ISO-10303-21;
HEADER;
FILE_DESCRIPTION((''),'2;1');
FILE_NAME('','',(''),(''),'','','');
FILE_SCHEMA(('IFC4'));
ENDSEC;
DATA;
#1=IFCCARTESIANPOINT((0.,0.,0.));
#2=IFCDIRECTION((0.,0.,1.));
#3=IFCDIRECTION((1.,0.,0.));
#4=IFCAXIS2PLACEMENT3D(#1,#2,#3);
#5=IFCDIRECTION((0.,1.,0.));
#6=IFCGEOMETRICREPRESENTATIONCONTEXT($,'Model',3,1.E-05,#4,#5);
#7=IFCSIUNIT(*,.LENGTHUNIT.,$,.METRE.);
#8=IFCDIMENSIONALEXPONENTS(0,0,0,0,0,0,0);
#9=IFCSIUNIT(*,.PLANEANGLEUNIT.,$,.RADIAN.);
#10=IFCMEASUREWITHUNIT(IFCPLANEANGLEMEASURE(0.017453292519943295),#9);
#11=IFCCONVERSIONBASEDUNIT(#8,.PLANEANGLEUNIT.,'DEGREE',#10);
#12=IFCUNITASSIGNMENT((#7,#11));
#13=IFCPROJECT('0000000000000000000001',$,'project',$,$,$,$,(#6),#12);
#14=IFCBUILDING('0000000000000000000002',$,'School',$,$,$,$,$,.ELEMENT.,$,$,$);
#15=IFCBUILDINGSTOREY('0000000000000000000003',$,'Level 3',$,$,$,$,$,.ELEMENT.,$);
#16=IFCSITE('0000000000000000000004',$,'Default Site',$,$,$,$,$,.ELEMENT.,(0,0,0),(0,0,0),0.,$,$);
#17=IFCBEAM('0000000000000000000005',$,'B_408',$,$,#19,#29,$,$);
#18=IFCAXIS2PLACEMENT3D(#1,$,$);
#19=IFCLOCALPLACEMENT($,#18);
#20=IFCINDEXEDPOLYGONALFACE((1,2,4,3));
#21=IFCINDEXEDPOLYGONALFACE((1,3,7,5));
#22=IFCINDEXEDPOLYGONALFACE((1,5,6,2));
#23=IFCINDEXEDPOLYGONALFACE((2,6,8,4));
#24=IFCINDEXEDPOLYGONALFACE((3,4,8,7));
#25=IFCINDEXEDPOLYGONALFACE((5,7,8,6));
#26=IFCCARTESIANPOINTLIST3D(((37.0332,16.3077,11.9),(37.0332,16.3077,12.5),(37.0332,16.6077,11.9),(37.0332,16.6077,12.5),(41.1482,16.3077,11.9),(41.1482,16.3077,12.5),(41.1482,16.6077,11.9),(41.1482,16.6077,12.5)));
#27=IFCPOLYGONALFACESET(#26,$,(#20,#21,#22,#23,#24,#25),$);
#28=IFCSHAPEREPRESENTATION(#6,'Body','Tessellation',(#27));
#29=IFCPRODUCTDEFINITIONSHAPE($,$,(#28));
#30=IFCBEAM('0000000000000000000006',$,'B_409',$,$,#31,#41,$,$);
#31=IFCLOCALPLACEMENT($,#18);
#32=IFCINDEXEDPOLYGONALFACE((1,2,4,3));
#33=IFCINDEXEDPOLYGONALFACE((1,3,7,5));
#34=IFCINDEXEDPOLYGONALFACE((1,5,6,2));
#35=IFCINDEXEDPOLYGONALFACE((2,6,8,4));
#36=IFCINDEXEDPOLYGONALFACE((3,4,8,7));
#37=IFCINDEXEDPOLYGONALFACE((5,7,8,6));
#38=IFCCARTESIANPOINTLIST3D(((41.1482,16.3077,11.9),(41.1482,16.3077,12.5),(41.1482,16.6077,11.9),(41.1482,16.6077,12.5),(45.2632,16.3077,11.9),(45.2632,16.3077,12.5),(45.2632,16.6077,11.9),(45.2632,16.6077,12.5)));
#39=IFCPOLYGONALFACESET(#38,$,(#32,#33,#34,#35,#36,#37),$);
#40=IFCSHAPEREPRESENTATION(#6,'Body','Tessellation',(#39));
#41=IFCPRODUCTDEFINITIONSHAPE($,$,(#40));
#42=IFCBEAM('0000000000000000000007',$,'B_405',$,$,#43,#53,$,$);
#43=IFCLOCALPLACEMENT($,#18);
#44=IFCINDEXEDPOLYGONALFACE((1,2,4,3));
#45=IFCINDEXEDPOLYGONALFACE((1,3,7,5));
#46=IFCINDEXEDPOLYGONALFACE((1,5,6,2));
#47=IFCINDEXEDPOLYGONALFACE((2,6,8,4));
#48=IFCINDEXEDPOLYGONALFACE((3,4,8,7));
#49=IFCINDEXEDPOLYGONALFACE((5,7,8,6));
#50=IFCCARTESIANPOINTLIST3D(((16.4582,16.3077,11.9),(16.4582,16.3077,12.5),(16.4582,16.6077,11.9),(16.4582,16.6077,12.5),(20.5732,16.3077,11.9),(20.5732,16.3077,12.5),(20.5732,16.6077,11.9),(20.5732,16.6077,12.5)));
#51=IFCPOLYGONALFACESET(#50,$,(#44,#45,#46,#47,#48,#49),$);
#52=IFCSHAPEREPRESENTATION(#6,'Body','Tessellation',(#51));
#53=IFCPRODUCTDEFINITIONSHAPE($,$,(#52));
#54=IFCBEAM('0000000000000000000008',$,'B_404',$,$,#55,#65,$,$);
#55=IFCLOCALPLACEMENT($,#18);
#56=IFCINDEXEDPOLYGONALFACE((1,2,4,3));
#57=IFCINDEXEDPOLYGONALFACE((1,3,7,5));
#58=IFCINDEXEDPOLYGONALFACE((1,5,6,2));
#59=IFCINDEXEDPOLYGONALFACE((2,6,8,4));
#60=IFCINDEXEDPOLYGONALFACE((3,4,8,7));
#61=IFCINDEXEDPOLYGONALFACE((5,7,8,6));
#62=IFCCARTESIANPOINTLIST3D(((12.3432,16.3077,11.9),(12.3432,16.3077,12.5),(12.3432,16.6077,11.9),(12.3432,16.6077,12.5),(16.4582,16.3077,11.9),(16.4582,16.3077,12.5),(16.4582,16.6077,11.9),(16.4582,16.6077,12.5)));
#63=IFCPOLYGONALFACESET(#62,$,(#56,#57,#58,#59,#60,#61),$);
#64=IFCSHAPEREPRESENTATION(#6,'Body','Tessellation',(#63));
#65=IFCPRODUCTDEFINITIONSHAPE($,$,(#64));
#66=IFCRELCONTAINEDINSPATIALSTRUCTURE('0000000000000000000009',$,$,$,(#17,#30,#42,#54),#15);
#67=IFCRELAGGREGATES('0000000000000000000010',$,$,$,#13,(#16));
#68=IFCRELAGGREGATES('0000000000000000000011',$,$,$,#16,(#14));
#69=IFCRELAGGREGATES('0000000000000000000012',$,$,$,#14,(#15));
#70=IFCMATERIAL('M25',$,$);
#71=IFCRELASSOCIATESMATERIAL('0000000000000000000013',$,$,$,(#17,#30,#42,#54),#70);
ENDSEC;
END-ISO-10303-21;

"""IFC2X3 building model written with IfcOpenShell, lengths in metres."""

from ifc_helpers import new_model, entity, si_unit, converted_unit, direction, frame, frame_2d, origin_with_axes, place, context, project, spatial, rectangle, extrude, material, element, save


model = new_model("IFC2X3")

# Units and contexts
model_context = context("Model", 3, precision=1e-05, world=origin_with_axes(), true_north=direction((0.0, 1.0, 0.0)))
ifc_project = project(units=[si_unit("LENGTHUNIT", "METRE"), converted_unit("PLANEANGLEUNIT", "DEGREE", entity("IfcPlaneAngleMeasure", 0.017453292519943295), si_unit("PLANEANGLEUNIT", "RADIAN"), dimensions=[0, 0, 0, 0, 0, 0, 0])], contexts=[model_context])

# Site, building, storey
site = spatial("IfcSite", under=ifc_project, Name="Default Site", CompositionType="ELEMENT", RefLatitude=(0, 0, 0), RefLongitude=(0, 0, 0), RefElevation=0.0)
building = spatial("IfcBuilding", under=site, Name="School", CompositionType="ELEMENT")
storey = spatial("IfcBuildingStorey", under=building, Name="Level 3", CompositionType="ELEMENT")

# Beams
ifc_material = material(Name="M25")
placement = place(None, origin_with_axes())
element("IfcBeam", 1, at=placement, inside=storey, material=ifc_material, Name="B_408", context=model_context, shape_type="SweptSolid", body=[
    extrude(rectangle(XDim=0.3, YDim=0.6, at=frame_2d((0.0, 0.0), x_axis=(0.0, 1.0, 0.0))), frame((37.0332, 16.4577, 12.2), z_axis=(1.0, 0.0, 0.0), x_axis=(0.0, 0.0, -1.0)), (0.0, 0.0, 1.0), 4.115),
])
element("IfcBeam", 2, at=placement, inside=storey, material=ifc_material, Name="B_409", context=model_context, shape_type="SweptSolid", body=[
    extrude(rectangle(XDim=0.3, YDim=0.6, at=frame_2d((0.0, 0.0), x_axis=(0.0, 1.0, 0.0))), frame((41.1482, 16.4577, 12.2), z_axis=(1.0, 0.0, 0.0), x_axis=(0.0, 0.0, -1.0)), (0.0, 0.0, 1.0), 4.115),
])
element("IfcBeam", 3, at=placement, inside=storey, material=ifc_material, Name="B_405", context=model_context, shape_type="SweptSolid", body=[
    extrude(rectangle(XDim=0.3, YDim=0.6, at=frame_2d((0.0, 0.0), x_axis=(0.0, 1.0, 0.0))), frame((16.4582, 16.4577, 12.2), z_axis=(1.0, 0.0, 0.0), x_axis=(0.0, 0.0, -1.0)), (0.0, 0.0, 1.0), 4.115),
])
element("IfcBeam", 4, at=placement, inside=storey, material=ifc_material, Name="B_404", context=model_context, shape_type="SweptSolid", body=[
    extrude(rectangle(XDim=0.3, YDim=0.6, at=frame_2d((0.0, 0.0), x_axis=(0.0, 1.0, 0.0))), frame((12.3432, 16.4577, 12.2), z_axis=(1.0, 0.0, 0.0), x_axis=(0.0, 0.0, -1.0)), (0.0, 0.0, 1.0), 4.115),
])

save(model, "model.ifc")
